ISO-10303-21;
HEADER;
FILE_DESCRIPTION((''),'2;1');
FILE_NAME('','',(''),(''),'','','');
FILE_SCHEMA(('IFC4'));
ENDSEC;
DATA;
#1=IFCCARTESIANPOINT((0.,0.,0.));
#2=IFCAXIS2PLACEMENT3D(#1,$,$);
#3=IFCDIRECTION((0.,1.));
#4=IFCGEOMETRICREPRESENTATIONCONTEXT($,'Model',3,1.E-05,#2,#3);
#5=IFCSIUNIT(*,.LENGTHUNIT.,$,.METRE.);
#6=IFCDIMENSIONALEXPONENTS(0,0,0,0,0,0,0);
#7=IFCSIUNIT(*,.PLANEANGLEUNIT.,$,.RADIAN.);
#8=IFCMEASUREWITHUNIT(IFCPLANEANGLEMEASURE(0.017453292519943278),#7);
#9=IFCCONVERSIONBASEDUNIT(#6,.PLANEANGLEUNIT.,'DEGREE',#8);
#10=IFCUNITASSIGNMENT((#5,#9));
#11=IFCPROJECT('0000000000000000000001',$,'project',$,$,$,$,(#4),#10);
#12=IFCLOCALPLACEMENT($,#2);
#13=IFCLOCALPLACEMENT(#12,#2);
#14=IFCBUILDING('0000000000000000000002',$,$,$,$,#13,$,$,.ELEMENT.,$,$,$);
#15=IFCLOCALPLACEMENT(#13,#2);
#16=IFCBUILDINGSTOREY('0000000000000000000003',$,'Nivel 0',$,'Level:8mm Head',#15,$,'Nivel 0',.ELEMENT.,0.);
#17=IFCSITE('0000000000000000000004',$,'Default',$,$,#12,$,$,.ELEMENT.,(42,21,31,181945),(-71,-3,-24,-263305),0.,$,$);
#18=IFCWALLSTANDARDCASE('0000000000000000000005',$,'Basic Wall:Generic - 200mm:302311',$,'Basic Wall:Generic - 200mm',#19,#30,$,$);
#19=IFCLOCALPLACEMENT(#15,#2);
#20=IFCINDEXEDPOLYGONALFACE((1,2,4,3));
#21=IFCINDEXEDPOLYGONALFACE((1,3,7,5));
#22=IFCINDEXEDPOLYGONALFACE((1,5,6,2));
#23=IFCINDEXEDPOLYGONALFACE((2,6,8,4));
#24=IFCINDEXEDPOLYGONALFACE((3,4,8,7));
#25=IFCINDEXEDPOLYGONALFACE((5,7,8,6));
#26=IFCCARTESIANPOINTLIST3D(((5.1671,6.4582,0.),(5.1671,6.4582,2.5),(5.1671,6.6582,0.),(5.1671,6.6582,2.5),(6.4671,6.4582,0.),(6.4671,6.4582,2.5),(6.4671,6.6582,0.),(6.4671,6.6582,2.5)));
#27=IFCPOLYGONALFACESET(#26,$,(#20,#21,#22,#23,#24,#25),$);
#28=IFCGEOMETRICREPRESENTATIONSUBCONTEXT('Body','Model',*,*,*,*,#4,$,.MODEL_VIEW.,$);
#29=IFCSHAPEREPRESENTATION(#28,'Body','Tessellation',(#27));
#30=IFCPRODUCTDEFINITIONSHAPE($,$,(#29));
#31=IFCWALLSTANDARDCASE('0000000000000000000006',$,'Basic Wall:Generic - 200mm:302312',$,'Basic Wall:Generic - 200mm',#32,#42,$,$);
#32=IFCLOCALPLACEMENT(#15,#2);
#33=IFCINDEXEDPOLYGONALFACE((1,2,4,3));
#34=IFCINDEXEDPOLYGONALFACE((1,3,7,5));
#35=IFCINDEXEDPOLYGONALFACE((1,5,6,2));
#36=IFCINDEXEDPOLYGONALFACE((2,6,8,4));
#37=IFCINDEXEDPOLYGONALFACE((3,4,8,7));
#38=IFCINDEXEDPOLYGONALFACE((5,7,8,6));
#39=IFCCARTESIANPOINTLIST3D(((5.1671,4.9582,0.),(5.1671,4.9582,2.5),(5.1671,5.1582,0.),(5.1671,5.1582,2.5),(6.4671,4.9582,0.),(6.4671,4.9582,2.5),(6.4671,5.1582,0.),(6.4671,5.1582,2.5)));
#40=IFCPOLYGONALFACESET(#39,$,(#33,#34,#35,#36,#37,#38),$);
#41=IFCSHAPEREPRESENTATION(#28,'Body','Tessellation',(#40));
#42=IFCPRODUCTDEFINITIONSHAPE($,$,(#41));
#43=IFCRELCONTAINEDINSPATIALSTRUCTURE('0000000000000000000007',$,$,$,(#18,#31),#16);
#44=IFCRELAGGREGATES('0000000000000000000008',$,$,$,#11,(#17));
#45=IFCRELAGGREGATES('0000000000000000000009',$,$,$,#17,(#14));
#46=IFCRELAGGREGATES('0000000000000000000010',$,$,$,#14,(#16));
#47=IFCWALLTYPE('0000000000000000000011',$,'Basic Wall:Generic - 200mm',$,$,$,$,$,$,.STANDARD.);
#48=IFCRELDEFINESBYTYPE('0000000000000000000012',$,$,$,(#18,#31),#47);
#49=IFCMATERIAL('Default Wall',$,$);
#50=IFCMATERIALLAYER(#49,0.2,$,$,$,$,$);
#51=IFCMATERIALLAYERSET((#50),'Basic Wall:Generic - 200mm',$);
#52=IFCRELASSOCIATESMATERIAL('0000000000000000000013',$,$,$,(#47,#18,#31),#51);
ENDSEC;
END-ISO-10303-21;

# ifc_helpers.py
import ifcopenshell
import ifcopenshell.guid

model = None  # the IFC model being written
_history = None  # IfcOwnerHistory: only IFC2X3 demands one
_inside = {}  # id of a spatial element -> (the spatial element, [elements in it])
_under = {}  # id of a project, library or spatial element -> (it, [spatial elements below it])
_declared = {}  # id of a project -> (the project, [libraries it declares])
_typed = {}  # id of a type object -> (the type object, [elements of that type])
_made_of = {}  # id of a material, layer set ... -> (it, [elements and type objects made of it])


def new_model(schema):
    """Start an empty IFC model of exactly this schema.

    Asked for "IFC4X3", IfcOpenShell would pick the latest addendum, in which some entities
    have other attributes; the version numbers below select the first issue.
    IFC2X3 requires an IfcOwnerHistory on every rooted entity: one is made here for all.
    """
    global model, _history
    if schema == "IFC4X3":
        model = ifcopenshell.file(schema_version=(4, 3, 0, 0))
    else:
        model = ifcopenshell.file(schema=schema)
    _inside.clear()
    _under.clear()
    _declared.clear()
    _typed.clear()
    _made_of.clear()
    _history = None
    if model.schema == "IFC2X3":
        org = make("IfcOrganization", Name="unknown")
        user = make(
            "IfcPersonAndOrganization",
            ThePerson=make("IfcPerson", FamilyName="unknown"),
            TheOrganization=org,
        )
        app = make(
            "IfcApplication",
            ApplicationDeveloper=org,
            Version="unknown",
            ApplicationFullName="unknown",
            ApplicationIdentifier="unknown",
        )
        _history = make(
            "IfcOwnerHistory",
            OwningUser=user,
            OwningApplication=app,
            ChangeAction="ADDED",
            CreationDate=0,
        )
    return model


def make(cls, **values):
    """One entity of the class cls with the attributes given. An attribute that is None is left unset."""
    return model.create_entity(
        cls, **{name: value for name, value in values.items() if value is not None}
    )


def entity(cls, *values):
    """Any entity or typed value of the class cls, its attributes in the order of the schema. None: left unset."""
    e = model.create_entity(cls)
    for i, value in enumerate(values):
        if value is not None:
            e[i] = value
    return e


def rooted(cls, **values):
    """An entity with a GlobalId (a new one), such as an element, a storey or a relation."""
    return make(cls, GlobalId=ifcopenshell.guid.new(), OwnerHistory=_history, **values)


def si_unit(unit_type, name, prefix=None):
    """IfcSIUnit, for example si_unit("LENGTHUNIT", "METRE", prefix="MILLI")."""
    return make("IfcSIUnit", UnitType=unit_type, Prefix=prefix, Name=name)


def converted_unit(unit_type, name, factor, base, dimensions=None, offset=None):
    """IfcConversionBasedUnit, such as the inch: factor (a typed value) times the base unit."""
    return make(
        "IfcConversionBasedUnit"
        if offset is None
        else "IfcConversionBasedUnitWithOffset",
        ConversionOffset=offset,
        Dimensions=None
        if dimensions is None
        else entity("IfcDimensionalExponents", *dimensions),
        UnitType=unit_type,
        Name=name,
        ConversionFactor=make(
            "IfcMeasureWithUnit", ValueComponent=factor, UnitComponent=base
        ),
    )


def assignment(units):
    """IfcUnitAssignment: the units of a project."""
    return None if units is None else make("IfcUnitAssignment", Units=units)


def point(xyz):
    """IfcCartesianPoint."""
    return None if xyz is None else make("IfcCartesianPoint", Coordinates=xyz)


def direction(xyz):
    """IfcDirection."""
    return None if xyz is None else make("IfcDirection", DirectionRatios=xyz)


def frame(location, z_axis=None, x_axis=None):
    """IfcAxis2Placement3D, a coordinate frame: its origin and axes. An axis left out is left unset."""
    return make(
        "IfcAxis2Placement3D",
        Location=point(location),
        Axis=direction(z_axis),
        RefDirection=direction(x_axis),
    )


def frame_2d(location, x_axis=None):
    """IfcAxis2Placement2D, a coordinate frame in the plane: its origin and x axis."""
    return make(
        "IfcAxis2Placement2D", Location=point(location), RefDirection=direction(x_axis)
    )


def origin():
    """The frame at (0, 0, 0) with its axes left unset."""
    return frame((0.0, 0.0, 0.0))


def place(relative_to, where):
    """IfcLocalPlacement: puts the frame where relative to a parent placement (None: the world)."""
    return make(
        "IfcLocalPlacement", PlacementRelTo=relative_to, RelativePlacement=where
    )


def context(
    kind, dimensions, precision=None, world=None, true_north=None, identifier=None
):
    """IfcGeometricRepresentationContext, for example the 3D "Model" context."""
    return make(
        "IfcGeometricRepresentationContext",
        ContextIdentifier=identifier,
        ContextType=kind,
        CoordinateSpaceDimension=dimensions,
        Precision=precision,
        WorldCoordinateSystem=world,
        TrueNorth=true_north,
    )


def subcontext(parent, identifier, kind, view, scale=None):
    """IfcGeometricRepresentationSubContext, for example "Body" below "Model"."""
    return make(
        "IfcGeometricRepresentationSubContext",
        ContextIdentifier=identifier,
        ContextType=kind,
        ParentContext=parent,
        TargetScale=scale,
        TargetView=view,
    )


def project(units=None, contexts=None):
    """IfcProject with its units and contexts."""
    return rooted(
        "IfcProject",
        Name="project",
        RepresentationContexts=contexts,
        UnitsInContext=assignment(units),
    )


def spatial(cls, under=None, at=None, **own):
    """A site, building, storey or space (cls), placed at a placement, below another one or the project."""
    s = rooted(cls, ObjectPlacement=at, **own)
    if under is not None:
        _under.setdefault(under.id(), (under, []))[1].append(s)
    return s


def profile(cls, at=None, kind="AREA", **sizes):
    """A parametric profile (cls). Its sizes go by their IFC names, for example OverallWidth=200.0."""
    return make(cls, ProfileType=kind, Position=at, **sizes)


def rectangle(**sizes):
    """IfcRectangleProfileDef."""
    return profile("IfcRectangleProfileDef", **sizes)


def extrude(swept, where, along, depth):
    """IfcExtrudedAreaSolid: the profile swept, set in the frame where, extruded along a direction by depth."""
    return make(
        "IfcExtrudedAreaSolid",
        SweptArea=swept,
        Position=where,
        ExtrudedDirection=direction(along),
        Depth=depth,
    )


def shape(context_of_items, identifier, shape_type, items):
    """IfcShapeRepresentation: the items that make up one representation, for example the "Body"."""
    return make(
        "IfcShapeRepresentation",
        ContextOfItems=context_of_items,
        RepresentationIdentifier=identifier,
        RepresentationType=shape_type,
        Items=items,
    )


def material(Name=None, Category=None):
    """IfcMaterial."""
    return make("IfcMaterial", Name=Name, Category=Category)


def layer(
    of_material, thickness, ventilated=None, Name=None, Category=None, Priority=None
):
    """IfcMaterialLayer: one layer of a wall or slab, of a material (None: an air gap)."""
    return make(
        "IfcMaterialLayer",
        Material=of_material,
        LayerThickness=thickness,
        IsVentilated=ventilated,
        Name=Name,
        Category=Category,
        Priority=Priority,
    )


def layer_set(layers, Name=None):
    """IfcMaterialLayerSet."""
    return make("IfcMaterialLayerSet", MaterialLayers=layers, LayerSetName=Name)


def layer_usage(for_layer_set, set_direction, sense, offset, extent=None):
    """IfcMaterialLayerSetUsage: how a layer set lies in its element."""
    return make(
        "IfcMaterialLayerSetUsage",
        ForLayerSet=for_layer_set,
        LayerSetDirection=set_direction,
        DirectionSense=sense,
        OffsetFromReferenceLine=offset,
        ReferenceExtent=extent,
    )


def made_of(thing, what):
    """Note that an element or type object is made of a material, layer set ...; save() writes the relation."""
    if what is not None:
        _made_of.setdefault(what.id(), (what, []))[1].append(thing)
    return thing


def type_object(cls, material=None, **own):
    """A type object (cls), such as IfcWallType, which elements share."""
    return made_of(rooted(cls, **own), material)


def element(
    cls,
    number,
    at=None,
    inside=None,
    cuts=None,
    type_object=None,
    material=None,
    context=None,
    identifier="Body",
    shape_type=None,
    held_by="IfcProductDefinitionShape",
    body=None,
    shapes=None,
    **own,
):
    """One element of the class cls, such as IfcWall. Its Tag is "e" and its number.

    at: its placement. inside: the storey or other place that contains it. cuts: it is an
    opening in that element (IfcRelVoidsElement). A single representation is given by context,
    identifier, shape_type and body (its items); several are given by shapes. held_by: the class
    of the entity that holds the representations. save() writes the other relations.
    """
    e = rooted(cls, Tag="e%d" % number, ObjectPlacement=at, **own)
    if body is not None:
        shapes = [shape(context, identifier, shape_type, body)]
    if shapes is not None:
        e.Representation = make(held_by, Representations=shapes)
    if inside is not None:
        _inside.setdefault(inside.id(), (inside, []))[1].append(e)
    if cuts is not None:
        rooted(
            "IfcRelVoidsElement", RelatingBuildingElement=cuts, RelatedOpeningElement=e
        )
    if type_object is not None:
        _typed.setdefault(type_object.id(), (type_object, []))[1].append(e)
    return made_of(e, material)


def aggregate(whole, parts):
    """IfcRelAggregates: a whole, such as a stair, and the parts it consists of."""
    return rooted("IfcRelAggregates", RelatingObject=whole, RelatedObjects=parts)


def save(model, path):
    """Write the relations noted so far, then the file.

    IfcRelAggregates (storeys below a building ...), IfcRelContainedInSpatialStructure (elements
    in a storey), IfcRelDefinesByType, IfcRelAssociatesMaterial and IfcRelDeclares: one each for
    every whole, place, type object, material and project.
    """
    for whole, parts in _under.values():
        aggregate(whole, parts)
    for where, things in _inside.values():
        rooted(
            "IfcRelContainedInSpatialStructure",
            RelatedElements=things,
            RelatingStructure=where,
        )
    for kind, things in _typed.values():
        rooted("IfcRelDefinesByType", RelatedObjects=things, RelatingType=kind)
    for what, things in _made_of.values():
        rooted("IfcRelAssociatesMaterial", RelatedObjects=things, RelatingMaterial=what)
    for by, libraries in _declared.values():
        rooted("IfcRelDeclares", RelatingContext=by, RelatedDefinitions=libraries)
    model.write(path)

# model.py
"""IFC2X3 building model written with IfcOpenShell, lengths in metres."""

from ifc_helpers import new_model, entity, si_unit, converted_unit, direction, frame, frame_2d, origin, place, context, subcontext, project, spatial, rectangle, extrude, material, layer, layer_set, layer_usage, type_object, element, save


model = new_model("IFC2X3")

# Units and contexts
model_context = context("Model", 3, precision=1e-05, world=origin(), true_north=direction((0.0, 1.0)))
body_context = subcontext(model_context, "Body", "Model", "MODEL_VIEW")
ifc_project = project(units=[si_unit("LENGTHUNIT", "METRE"), converted_unit("PLANEANGLEUNIT", "DEGREE", entity("IfcPlaneAngleMeasure", 0.017453292519943278), si_unit("PLANEANGLEUNIT", "RADIAN"), dimensions=[0, 0, 0, 0, 0, 0, 0])], contexts=[model_context])

# Site, building, storey
site_placement = place(None, origin())
site = spatial("IfcSite", under=ifc_project, at=site_placement, Name="Default", CompositionType="ELEMENT", RefLatitude=(42, 21, 31, 181945), RefLongitude=(-71, -3, -24, -263305), RefElevation=0.0)
building_placement = place(site_placement, origin())
building = spatial("IfcBuilding", under=site, at=building_placement, CompositionType="ELEMENT")
storey_placement = place(building_placement, origin())
storey = spatial("IfcBuildingStorey", under=building, at=storey_placement, Name="Nivel 0", ObjectType="Level:8mm Head", LongName="Nivel 0", CompositionType="ELEMENT", Elevation=0.0)

# Shared definitions
ifc_material_1 = material(Name="Default Wall")
ifc_layer = layer(ifc_material_1, 0.2)
ifc_layer_set = layer_set([ifc_layer], Name="Basic Wall:Generic - 200mm")
wall_type = type_object("IfcWallType", Name="Basic Wall:Generic - 200mm", PredefinedType="STANDARD", material=ifc_layer_set)

# Walls
ifc_layer_usage_1 = layer_usage(ifc_layer_set, "AXIS2", "NEGATIVE", 0.1)
wall_1_placement = place(storey_placement, frame((5.1671, 6.5582, 0.0)))
element("IfcWallStandardCase", 1, at=wall_1_placement, inside=storey, type_object=wall_type, material=ifc_layer_usage_1, Name="Basic Wall:Generic - 200mm:302311", ObjectType="Basic Wall:Generic - 200mm", context=body_context, shape_type="SweptSolid", body=[
    extrude(rectangle(XDim=1.3, YDim=0.2, at=frame_2d((0.65, 0.0), x_axis=(-1.0, 0.0))), origin(), (0.0, 0.0, 1.0), 2.5),
])
ifc_layer_usage_2 = layer_usage(ifc_layer_set, "AXIS2", "NEGATIVE", 0.1)
wall_2_placement = place(storey_placement, frame((5.1671, 5.0582, 0.0)))
element("IfcWallStandardCase", 2, at=wall_2_placement, inside=storey, type_object=wall_type, material=ifc_layer_usage_2, Name="Basic Wall:Generic - 200mm:302312", ObjectType="Basic Wall:Generic - 200mm", context=body_context, shape_type="SweptSolid", body=[
    extrude(rectangle(XDim=1.3, YDim=0.2, at=frame_2d((0.65, 0.0), x_axis=(-1.0, 0.0))), origin(), (0.0, 0.0, 1.0), 2.5),
])

save(model, "model.ifc")
